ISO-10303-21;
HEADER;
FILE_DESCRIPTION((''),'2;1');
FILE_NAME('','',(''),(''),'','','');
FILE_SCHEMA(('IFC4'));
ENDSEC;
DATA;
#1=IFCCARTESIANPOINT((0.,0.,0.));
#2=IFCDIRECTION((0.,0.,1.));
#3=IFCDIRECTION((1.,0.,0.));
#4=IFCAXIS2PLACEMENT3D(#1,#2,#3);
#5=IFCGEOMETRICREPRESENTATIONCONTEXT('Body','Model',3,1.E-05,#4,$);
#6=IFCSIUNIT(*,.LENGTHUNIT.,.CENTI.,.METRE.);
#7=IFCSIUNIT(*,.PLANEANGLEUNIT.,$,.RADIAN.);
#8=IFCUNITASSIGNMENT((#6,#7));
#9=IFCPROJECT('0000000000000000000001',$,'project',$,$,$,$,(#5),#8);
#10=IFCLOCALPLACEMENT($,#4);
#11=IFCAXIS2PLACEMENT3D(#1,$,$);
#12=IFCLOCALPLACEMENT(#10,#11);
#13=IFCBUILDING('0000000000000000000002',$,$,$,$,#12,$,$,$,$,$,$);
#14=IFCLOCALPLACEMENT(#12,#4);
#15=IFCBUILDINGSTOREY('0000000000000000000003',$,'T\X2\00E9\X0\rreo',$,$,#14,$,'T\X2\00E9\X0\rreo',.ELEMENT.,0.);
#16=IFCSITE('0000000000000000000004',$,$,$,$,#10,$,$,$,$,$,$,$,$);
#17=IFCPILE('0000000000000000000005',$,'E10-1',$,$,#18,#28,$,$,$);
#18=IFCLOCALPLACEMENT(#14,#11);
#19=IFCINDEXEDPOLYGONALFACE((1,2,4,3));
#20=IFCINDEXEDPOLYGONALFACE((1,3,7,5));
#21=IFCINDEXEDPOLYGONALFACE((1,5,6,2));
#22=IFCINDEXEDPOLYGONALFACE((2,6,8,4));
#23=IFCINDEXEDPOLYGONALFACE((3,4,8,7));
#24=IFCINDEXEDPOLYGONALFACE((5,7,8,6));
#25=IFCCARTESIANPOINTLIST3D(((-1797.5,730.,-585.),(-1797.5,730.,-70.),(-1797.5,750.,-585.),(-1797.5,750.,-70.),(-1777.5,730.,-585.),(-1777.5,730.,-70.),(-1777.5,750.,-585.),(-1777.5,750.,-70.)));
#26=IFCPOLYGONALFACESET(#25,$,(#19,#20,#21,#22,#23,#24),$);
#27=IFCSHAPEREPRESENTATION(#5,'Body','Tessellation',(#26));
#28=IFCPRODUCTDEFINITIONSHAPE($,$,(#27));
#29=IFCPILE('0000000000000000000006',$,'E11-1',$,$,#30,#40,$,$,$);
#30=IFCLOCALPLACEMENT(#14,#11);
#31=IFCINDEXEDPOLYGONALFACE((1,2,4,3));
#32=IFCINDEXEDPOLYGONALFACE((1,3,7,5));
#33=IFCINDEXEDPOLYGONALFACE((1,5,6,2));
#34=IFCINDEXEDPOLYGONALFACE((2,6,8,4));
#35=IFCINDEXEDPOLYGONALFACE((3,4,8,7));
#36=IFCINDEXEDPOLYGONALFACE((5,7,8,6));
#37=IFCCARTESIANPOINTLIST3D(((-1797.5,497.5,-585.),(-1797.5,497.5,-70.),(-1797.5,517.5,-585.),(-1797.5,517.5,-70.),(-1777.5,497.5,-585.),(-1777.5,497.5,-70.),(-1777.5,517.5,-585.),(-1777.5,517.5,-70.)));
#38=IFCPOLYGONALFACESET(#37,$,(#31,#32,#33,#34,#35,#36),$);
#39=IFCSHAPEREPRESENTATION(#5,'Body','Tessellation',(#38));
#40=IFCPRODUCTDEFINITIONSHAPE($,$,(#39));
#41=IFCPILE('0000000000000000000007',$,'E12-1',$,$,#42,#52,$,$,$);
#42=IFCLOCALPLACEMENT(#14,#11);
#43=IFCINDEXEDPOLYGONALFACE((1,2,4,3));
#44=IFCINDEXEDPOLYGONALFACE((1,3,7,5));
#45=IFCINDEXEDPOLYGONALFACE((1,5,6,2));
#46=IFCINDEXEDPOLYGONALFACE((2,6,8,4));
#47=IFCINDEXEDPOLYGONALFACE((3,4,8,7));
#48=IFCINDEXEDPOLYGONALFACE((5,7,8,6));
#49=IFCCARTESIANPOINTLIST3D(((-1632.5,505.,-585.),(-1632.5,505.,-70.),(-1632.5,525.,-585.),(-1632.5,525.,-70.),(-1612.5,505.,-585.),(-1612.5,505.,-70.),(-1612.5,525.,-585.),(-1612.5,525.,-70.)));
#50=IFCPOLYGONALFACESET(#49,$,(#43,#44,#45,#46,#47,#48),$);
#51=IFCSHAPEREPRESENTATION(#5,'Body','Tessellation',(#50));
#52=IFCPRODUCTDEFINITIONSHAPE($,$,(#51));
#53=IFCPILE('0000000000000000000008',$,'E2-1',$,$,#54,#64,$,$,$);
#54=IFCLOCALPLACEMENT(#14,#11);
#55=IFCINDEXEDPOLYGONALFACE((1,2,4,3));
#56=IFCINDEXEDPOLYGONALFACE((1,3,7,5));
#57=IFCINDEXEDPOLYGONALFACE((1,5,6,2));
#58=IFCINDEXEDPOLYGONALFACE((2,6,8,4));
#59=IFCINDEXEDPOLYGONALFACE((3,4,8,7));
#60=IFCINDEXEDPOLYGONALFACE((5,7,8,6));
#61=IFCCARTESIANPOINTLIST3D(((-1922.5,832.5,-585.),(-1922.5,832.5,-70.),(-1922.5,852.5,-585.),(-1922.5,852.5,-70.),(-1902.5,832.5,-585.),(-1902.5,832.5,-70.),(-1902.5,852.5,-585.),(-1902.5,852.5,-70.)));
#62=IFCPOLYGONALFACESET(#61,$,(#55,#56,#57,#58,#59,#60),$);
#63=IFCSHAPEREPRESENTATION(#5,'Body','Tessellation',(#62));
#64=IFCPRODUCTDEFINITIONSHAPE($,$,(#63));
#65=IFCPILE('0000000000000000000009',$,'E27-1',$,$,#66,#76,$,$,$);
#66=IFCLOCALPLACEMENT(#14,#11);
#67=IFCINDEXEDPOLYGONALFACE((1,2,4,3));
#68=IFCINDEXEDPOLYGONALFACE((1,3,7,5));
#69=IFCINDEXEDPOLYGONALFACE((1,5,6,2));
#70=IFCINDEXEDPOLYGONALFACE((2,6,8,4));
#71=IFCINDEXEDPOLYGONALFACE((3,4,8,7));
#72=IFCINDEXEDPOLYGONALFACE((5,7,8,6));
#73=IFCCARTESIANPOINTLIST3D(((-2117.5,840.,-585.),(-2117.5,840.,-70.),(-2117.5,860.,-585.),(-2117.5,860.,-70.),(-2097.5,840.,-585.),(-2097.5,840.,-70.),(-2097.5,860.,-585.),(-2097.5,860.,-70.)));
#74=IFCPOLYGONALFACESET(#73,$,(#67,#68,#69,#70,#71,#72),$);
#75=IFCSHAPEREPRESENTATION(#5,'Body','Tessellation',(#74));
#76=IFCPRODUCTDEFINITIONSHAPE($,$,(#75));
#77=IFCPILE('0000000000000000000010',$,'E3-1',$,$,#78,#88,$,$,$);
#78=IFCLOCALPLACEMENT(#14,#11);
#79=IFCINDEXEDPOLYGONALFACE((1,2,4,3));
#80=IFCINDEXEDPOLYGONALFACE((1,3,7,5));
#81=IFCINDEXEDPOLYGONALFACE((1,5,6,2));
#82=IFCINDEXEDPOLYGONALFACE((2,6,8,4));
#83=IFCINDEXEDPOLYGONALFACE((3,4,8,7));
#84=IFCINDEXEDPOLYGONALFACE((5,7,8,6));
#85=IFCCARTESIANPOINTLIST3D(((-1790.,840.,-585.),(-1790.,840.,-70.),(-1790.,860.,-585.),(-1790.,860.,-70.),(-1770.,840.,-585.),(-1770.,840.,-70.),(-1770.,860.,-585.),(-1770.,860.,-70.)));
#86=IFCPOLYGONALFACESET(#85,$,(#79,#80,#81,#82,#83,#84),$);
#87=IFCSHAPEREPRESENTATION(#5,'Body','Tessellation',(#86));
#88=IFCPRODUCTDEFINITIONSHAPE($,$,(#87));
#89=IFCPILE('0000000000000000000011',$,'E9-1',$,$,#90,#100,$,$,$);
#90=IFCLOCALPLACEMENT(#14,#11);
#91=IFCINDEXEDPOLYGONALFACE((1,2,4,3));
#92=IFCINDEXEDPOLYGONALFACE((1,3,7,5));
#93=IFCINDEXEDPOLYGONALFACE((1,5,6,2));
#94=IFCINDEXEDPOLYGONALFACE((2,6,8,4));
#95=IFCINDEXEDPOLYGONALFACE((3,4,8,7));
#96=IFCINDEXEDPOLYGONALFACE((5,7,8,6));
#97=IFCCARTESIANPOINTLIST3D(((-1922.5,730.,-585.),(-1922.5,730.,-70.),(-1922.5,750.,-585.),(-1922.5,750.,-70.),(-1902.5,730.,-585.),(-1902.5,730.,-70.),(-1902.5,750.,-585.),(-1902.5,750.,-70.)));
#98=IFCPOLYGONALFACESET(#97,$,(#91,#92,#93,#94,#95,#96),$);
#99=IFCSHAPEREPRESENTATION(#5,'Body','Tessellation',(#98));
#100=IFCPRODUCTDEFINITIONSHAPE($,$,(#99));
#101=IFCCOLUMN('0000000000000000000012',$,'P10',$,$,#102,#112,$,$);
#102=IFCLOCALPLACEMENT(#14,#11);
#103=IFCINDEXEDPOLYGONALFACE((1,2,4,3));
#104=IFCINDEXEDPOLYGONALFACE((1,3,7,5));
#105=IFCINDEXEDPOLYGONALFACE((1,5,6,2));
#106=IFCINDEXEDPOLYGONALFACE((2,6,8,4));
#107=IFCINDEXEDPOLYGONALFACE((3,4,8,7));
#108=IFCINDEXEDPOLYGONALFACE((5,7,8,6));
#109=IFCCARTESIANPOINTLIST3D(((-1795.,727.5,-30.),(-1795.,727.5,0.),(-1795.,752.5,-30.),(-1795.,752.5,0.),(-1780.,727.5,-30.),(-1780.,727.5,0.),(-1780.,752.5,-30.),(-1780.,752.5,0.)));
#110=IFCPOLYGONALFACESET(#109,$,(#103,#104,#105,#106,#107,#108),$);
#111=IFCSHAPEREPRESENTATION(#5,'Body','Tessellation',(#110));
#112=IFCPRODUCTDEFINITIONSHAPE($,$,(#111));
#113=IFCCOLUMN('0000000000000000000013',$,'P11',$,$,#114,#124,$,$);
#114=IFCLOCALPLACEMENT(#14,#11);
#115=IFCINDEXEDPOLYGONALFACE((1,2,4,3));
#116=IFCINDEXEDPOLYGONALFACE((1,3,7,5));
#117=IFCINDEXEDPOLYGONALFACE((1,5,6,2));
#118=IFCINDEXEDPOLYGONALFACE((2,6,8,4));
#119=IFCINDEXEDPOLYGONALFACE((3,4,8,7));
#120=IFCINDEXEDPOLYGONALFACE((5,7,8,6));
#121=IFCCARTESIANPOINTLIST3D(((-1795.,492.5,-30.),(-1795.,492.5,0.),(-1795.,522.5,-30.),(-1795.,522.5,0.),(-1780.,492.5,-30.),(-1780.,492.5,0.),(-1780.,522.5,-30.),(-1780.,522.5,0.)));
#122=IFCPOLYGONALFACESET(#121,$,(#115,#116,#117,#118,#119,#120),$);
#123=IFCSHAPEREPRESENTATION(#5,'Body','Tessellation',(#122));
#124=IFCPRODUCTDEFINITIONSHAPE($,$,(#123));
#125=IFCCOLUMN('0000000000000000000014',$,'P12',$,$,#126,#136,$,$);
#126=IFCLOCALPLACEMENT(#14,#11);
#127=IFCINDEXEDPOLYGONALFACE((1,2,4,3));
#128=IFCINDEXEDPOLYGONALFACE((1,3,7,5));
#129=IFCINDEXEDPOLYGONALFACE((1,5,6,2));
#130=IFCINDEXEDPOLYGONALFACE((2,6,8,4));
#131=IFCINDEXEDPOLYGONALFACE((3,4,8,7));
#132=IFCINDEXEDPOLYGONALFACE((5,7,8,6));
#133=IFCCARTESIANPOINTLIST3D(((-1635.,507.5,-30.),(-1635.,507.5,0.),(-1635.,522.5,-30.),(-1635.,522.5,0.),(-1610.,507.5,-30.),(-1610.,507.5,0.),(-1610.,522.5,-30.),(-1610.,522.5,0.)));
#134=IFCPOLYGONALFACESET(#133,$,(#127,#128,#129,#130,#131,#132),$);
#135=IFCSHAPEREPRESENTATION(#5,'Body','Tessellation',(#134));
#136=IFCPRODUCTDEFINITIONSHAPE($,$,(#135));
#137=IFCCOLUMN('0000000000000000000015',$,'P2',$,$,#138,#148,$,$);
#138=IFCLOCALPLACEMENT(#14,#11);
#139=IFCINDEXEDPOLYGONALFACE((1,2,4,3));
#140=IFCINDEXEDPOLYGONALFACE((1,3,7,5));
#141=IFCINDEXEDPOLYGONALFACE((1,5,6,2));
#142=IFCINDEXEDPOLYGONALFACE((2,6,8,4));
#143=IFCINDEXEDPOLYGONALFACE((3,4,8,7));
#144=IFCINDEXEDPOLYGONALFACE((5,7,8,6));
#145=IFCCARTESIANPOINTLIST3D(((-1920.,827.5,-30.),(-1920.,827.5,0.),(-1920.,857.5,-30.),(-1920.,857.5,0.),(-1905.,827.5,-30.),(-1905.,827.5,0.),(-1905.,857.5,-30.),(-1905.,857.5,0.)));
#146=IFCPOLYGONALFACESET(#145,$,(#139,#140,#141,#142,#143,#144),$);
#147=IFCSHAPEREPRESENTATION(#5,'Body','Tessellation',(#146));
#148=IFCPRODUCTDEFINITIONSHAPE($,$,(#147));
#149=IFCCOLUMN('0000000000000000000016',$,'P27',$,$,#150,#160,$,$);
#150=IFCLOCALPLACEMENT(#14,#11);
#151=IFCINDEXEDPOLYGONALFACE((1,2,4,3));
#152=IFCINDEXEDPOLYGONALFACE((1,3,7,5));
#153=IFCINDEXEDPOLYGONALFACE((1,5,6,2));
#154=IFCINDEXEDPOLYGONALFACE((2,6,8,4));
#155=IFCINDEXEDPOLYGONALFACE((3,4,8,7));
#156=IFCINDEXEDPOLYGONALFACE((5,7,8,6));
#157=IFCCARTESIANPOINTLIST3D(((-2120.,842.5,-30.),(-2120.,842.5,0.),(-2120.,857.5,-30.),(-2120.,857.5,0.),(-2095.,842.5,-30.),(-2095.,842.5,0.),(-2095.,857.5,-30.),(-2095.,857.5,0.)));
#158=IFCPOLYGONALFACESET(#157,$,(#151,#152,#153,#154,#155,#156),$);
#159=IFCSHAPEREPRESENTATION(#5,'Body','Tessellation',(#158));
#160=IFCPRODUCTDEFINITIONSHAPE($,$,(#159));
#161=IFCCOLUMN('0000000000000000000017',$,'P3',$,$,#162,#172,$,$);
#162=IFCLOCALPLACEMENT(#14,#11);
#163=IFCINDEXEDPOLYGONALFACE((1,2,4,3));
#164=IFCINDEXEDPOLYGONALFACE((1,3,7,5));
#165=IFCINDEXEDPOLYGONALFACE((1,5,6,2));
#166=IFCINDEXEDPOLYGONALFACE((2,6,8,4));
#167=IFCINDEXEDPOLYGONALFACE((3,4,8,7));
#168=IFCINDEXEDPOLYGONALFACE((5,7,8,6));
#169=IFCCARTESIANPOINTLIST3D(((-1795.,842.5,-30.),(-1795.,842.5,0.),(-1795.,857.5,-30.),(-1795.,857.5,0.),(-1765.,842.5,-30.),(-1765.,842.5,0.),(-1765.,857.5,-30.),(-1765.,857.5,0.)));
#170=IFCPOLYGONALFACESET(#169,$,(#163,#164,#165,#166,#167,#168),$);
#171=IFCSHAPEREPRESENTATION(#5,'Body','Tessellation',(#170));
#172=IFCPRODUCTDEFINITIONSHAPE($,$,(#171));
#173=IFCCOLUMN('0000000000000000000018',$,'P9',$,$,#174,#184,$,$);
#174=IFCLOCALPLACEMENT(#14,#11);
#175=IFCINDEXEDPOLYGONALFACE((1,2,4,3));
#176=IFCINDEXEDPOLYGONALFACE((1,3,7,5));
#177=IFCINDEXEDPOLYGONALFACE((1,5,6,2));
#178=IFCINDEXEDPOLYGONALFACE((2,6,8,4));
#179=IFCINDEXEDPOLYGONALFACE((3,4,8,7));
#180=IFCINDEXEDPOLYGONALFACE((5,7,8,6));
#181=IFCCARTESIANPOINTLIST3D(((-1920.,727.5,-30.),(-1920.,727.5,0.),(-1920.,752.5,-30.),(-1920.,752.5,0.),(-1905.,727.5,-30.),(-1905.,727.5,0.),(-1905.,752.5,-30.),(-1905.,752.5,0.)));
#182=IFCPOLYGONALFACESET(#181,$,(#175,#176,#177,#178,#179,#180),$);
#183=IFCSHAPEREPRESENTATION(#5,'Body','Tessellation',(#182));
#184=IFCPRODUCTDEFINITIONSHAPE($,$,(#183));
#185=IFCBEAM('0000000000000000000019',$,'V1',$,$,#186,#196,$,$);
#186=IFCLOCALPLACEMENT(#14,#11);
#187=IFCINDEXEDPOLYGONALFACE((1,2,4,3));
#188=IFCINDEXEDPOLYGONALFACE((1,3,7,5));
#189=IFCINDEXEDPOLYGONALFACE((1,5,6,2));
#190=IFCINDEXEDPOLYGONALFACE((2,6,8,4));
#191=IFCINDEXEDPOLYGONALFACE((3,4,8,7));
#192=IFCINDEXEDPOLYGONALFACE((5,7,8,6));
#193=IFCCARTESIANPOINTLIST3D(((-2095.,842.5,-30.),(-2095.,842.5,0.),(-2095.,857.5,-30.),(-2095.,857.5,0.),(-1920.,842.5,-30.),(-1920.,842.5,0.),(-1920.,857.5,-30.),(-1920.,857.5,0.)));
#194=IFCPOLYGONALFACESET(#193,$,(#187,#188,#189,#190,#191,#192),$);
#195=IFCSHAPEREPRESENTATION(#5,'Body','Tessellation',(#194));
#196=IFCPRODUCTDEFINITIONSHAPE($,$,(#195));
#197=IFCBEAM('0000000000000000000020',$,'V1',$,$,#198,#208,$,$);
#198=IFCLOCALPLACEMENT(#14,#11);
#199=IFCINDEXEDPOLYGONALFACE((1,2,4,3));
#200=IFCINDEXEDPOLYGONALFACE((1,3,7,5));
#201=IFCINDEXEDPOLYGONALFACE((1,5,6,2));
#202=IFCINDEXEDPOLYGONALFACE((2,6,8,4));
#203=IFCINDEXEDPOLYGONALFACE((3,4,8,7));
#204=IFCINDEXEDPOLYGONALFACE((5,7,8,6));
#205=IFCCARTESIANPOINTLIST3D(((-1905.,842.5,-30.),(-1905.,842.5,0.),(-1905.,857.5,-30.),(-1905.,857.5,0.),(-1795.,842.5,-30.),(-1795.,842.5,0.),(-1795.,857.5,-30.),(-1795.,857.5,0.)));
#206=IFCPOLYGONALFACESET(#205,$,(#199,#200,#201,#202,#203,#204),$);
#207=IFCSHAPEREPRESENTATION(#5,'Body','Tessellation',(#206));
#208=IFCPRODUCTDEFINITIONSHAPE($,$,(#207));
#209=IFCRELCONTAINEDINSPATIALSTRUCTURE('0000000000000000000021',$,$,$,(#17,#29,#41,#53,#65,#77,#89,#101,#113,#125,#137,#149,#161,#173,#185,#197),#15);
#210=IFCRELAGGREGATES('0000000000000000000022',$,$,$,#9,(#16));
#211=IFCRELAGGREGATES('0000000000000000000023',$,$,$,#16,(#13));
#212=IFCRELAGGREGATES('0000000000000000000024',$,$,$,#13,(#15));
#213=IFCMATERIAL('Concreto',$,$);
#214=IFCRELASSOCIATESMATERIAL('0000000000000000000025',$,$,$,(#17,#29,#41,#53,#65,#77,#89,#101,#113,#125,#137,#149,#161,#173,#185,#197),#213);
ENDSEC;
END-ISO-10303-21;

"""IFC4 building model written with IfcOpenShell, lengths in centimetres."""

from ifc_helpers import new_model, si_unit, frame, origin, origin_with_axes, origin_2d_with_axis, place, context, project, spatial, rectangle, extrude, material, element, save


model = new_model("IFC4")

# Units and contexts
model_context = context("Model", 3, precision=1e-05, world=origin_with_axes(), identifier="Body")
ifc_project = project(units=[si_unit("LENGTHUNIT", "METRE", prefix="CENTI"), si_unit("PLANEANGLEUNIT", "RADIAN")], contexts=[model_context])

# Site, building, storey
site_placement = place(None, origin_with_axes())
site = spatial("IfcSite", under=ifc_project, at=site_placement)
building_placement = place(site_placement, origin())
building = spatial("IfcBuilding", under=site, at=building_placement)
storey_placement = place(building_placement, origin_with_axes())
storey = spatial("IfcBuildingStorey", under=building, at=storey_placement, Name="Térreo", LongName="Térreo", CompositionType="ELEMENT", Elevation=0.0)

# Piles
ifc_material = material(Name="Concreto")
for number, where, z_axis, x_axis, name in (
    (1, (-1787.5, 740.0, -70.0), (0.0, 0.0, 1.0), (1.0, 0.0, 0.0), "E10-1"),
    (2, (-1787.5, 507.5, -70.0), (0.0, 0.0, 1.0), (1.0, 0.0, 0.0), "E11-1"),
):
    element("IfcPile", number, at=place(storey_placement, frame(where, z_axis=z_axis, x_axis=x_axis)), inside=storey, material=ifc_material, Name=name, context=model_context, shape_type="SweptSolid", body=[
        extrude(rectangle(XDim=20.0, YDim=20.0, at=origin_2d_with_axis()), frame((0.0, 0.0, -515.0), z_axis=(0.0, 0.0, 1.0), x_axis=(1.0, 0.0, 0.0)), (0.0, 0.0, 1.0), 515.0),
    ])
pile_1_placement = place(storey_placement, frame((-1622.5, 515.0, -70.0), z_axis=(0.0, 0.0, 1.0), x_axis=(1.0, 0.0, 0.0)))
element("IfcPile", 3, at=pile_1_placement, inside=storey, material=ifc_material, Name="E12-1", context=model_context, shape_type="SweptSolid", body=[
    extrude(rectangle(XDim=20.0, YDim=20.0, at=origin_2d_with_axis()), frame((0.0, 0.0, -515.0), z_axis=(0.0, 0.0, 1.0), x_axis=(0.0, 1.0, 0.0)), (0.0, 0.0, 1.0), 515.0),
])
pile_2_placement = place(storey_placement, frame((-1912.5, 842.5, -70.0), z_axis=(0.0, 0.0, 1.0), x_axis=(1.0, 0.0, 0.0)))
element("IfcPile", 4, at=pile_2_placement, inside=storey, material=ifc_material, Name="E2-1", context=model_context, shape_type="SweptSolid", body=[
    extrude(rectangle(XDim=20.0, YDim=20.0, at=origin_2d_with_axis()), frame((0.0, 0.0, -515.0), z_axis=(0.0, 0.0, 1.0), x_axis=(1.0, 0.0, 0.0)), (0.0, 0.0, 1.0), 515.0),
])
for number, where, z_axis, x_axis, name in (
    (5, (-2107.5, 850.0, -70.0), (0.0, 0.0, 1.0), (1.0, 0.0, 0.0), "E27-1"),
    (6, (-1780.0, 850.0, -70.0), (0.0, 0.0, 1.0), (1.0, 0.0, 0.0), "E3-1"),
):
    element("IfcPile", number, at=place(storey_placement, frame(where, z_axis=z_axis, x_axis=x_axis)), inside=storey, material=ifc_material, Name=name, context=model_context, shape_type="SweptSolid", body=[
        extrude(rectangle(XDim=20.0, YDim=20.0, at=origin_2d_with_axis()), frame((0.0, 0.0, -515.0), z_axis=(0.0, 0.0, 1.0), x_axis=(0.0, 1.0, 0.0)), (0.0, 0.0, 1.0), 515.0),
    ])
pile_3_placement = place(storey_placement, frame((-1912.5, 740.0, -70.0), z_axis=(0.0, 0.0, 1.0), x_axis=(1.0, 0.0, 0.0)))
element("IfcPile", 7, at=pile_3_placement, inside=storey, material=ifc_material, Name="E9-1", context=model_context, shape_type="SweptSolid", body=[
    extrude(rectangle(XDim=20.0, YDim=20.0, at=origin_2d_with_axis()), frame((0.0, 0.0, -515.0), z_axis=(0.0, 0.0, 1.0), x_axis=(-1.0, 0.0, 0.0)), (0.0, 0.0, 1.0), 515.0),
])

# Columns
column_1_placement = place(storey_placement, frame((-1787.5, 740.0, 0.0), z_axis=(0.0, 0.0, 1.0), x_axis=(1.0, 0.0, 0.0)))
element("IfcColumn", 8, at=column_1_placement, inside=storey, material=ifc_material, Name="P10", context=model_context, shape_type="SolidModel", body=[
    extrude(rectangle(XDim=15.0, YDim=25.0, at=origin_2d_with_axis()), frame((0.0, 0.0, -30.0), z_axis=(0.0, 0.0, 1.0), x_axis=(1.0, 0.0, 0.0)), (0.0, 0.0, 1.0), 30.0),
])
column_2_placement = place(storey_placement, frame((-1787.5, 507.5, 0.0), z_axis=(0.0, 0.0, 1.0), x_axis=(1.0, 0.0, 0.0)))
element("IfcColumn", 9, at=column_2_placement, inside=storey, material=ifc_material, Name="P11", context=model_context, shape_type="SolidModel", body=[
    extrude(rectangle(XDim=15.0, YDim=30.0, at=origin_2d_with_axis()), frame((0.0, 0.0, -30.0), z_axis=(0.0, 0.0, 1.0), x_axis=(1.0, 0.0, 0.0)), (0.0, 0.0, 1.0), 30.0),
])
column_3_placement = place(storey_placement, frame((-1622.5, 515.0, 0.0), z_axis=(0.0, 0.0, 1.0), x_axis=(1.0, 0.0, 0.0)))
element("IfcColumn", 10, at=column_3_placement, inside=storey, material=ifc_material, Name="P12", context=model_context, shape_type="SolidModel", body=[
    extrude(rectangle(XDim=15.0, YDim=25.0, at=origin_2d_with_axis()), frame((0.0, 0.0, -30.0), z_axis=(0.0, 0.0, 1.0), x_axis=(0.0, 1.0, 0.0)), (0.0, 0.0, 1.0), 30.0),
])
column_4_placement = place(storey_placement, frame((-1912.5, 842.5, 0.0), z_axis=(0.0, 0.0, 1.0), x_axis=(1.0, 0.0, 0.0)))
element("IfcColumn", 11, at=column_4_placement, inside=storey, material=ifc_material, Name="P2", context=model_context, shape_type="SolidModel", body=[
    extrude(rectangle(XDim=15.0, YDim=30.0, at=origin_2d_with_axis()), frame((0.0, 0.0, -30.0), z_axis=(0.0, 0.0, 1.0), x_axis=(1.0, 0.0, 0.0)), (0.0, 0.0, 1.0), 30.0),
])
column_5_placement = place(storey_placement, frame((-2107.5, 850.0, 0.0), z_axis=(0.0, 0.0, 1.0), x_axis=(1.0, 0.0, 0.0)))
element("IfcColumn", 12, at=column_5_placement, inside=storey, material=ifc_material, Name="P27", context=model_context, shape_type="SolidModel", body=[
    extrude(rectangle(XDim=15.0, YDim=25.0, at=origin_2d_with_axis()), frame((0.0, 0.0, -30.0), z_axis=(0.0, 0.0, 1.0), x_axis=(0.0, 1.0, 0.0)), (0.0, 0.0, 1.0), 30.0),
])
column_6_placement = place(storey_placement, frame((-1780.0, 850.0, 0.0), z_axis=(0.0, 0.0, 1.0), x_axis=(1.0, 0.0, 0.0)))
element("IfcColumn", 13, at=column_6_placement, inside=storey, material=ifc_material, Name="P3", context=model_context, shape_type="SolidModel", body=[
    extrude(rectangle(XDim=15.0, YDim=30.0, at=origin_2d_with_axis()), frame((0.0, 0.0, -30.0), z_axis=(0.0, 0.0, 1.0), x_axis=(0.0, 1.0, 0.0)), (0.0, 0.0, 1.0), 30.0),
])
column_7_placement = place(storey_placement, frame((-1912.5, 740.0, 0.0), z_axis=(0.0, 0.0, 1.0), x_axis=(1.0, 0.0, 0.0)))
element("IfcColumn", 14, at=column_7_placement, inside=storey, material=ifc_material, Name="P9", context=model_context, shape_type="SolidModel", body=[
    extrude(rectangle(XDim=15.0, YDim=25.0, at=origin_2d_with_axis()), frame((0.0, 0.0, -30.0), z_axis=(0.0, 0.0, 1.0), x_axis=(-1.0, 0.0, 0.0)), (0.0, 0.0, 1.0), 30.0),
])

# Beams
beam_1_placement = place(storey_placement, frame((-2007.5, 850.0, 0.0), z_axis=(0.0, 0.0, 1.0), x_axis=(1.0, 0.0, 0.0)))
element("IfcBeam", 15, at=beam_1_placement, inside=storey, material=ifc_material, Name="V1", context=model_context, shape_type="SolidModel", body=[
    extrude(rectangle(XDim=15.0, YDim=30.0, at=origin_2d_with_axis()), frame((-87.5, 0.0, -15.0), z_axis=(1.0, 0.0, 0.0), x_axis=(0.0, -1.0, 0.0)), (0.0, 0.0, 1.0), 175.0),
])
beam_2_placement = place(storey_placement, frame((-1850.0, 850.0, 0.0), z_axis=(0.0, 0.0, 1.0), x_axis=(1.0, 0.0, 0.0)))
element("IfcBeam", 16, at=beam_2_placement, inside=storey, material=ifc_material, Name="V1", context=model_context, shape_type="SolidModel", body=[
    extrude(rectangle(XDim=15.0, YDim=30.0, at=origin_2d_with_axis()), frame((-55.0, 0.0, -15.0), z_axis=(1.0, 0.0, 0.0), x_axis=(0.0, -1.0, 0.0)), (0.0, 0.0, 1.0), 110.0),
])

save(model, "model.ifc")
